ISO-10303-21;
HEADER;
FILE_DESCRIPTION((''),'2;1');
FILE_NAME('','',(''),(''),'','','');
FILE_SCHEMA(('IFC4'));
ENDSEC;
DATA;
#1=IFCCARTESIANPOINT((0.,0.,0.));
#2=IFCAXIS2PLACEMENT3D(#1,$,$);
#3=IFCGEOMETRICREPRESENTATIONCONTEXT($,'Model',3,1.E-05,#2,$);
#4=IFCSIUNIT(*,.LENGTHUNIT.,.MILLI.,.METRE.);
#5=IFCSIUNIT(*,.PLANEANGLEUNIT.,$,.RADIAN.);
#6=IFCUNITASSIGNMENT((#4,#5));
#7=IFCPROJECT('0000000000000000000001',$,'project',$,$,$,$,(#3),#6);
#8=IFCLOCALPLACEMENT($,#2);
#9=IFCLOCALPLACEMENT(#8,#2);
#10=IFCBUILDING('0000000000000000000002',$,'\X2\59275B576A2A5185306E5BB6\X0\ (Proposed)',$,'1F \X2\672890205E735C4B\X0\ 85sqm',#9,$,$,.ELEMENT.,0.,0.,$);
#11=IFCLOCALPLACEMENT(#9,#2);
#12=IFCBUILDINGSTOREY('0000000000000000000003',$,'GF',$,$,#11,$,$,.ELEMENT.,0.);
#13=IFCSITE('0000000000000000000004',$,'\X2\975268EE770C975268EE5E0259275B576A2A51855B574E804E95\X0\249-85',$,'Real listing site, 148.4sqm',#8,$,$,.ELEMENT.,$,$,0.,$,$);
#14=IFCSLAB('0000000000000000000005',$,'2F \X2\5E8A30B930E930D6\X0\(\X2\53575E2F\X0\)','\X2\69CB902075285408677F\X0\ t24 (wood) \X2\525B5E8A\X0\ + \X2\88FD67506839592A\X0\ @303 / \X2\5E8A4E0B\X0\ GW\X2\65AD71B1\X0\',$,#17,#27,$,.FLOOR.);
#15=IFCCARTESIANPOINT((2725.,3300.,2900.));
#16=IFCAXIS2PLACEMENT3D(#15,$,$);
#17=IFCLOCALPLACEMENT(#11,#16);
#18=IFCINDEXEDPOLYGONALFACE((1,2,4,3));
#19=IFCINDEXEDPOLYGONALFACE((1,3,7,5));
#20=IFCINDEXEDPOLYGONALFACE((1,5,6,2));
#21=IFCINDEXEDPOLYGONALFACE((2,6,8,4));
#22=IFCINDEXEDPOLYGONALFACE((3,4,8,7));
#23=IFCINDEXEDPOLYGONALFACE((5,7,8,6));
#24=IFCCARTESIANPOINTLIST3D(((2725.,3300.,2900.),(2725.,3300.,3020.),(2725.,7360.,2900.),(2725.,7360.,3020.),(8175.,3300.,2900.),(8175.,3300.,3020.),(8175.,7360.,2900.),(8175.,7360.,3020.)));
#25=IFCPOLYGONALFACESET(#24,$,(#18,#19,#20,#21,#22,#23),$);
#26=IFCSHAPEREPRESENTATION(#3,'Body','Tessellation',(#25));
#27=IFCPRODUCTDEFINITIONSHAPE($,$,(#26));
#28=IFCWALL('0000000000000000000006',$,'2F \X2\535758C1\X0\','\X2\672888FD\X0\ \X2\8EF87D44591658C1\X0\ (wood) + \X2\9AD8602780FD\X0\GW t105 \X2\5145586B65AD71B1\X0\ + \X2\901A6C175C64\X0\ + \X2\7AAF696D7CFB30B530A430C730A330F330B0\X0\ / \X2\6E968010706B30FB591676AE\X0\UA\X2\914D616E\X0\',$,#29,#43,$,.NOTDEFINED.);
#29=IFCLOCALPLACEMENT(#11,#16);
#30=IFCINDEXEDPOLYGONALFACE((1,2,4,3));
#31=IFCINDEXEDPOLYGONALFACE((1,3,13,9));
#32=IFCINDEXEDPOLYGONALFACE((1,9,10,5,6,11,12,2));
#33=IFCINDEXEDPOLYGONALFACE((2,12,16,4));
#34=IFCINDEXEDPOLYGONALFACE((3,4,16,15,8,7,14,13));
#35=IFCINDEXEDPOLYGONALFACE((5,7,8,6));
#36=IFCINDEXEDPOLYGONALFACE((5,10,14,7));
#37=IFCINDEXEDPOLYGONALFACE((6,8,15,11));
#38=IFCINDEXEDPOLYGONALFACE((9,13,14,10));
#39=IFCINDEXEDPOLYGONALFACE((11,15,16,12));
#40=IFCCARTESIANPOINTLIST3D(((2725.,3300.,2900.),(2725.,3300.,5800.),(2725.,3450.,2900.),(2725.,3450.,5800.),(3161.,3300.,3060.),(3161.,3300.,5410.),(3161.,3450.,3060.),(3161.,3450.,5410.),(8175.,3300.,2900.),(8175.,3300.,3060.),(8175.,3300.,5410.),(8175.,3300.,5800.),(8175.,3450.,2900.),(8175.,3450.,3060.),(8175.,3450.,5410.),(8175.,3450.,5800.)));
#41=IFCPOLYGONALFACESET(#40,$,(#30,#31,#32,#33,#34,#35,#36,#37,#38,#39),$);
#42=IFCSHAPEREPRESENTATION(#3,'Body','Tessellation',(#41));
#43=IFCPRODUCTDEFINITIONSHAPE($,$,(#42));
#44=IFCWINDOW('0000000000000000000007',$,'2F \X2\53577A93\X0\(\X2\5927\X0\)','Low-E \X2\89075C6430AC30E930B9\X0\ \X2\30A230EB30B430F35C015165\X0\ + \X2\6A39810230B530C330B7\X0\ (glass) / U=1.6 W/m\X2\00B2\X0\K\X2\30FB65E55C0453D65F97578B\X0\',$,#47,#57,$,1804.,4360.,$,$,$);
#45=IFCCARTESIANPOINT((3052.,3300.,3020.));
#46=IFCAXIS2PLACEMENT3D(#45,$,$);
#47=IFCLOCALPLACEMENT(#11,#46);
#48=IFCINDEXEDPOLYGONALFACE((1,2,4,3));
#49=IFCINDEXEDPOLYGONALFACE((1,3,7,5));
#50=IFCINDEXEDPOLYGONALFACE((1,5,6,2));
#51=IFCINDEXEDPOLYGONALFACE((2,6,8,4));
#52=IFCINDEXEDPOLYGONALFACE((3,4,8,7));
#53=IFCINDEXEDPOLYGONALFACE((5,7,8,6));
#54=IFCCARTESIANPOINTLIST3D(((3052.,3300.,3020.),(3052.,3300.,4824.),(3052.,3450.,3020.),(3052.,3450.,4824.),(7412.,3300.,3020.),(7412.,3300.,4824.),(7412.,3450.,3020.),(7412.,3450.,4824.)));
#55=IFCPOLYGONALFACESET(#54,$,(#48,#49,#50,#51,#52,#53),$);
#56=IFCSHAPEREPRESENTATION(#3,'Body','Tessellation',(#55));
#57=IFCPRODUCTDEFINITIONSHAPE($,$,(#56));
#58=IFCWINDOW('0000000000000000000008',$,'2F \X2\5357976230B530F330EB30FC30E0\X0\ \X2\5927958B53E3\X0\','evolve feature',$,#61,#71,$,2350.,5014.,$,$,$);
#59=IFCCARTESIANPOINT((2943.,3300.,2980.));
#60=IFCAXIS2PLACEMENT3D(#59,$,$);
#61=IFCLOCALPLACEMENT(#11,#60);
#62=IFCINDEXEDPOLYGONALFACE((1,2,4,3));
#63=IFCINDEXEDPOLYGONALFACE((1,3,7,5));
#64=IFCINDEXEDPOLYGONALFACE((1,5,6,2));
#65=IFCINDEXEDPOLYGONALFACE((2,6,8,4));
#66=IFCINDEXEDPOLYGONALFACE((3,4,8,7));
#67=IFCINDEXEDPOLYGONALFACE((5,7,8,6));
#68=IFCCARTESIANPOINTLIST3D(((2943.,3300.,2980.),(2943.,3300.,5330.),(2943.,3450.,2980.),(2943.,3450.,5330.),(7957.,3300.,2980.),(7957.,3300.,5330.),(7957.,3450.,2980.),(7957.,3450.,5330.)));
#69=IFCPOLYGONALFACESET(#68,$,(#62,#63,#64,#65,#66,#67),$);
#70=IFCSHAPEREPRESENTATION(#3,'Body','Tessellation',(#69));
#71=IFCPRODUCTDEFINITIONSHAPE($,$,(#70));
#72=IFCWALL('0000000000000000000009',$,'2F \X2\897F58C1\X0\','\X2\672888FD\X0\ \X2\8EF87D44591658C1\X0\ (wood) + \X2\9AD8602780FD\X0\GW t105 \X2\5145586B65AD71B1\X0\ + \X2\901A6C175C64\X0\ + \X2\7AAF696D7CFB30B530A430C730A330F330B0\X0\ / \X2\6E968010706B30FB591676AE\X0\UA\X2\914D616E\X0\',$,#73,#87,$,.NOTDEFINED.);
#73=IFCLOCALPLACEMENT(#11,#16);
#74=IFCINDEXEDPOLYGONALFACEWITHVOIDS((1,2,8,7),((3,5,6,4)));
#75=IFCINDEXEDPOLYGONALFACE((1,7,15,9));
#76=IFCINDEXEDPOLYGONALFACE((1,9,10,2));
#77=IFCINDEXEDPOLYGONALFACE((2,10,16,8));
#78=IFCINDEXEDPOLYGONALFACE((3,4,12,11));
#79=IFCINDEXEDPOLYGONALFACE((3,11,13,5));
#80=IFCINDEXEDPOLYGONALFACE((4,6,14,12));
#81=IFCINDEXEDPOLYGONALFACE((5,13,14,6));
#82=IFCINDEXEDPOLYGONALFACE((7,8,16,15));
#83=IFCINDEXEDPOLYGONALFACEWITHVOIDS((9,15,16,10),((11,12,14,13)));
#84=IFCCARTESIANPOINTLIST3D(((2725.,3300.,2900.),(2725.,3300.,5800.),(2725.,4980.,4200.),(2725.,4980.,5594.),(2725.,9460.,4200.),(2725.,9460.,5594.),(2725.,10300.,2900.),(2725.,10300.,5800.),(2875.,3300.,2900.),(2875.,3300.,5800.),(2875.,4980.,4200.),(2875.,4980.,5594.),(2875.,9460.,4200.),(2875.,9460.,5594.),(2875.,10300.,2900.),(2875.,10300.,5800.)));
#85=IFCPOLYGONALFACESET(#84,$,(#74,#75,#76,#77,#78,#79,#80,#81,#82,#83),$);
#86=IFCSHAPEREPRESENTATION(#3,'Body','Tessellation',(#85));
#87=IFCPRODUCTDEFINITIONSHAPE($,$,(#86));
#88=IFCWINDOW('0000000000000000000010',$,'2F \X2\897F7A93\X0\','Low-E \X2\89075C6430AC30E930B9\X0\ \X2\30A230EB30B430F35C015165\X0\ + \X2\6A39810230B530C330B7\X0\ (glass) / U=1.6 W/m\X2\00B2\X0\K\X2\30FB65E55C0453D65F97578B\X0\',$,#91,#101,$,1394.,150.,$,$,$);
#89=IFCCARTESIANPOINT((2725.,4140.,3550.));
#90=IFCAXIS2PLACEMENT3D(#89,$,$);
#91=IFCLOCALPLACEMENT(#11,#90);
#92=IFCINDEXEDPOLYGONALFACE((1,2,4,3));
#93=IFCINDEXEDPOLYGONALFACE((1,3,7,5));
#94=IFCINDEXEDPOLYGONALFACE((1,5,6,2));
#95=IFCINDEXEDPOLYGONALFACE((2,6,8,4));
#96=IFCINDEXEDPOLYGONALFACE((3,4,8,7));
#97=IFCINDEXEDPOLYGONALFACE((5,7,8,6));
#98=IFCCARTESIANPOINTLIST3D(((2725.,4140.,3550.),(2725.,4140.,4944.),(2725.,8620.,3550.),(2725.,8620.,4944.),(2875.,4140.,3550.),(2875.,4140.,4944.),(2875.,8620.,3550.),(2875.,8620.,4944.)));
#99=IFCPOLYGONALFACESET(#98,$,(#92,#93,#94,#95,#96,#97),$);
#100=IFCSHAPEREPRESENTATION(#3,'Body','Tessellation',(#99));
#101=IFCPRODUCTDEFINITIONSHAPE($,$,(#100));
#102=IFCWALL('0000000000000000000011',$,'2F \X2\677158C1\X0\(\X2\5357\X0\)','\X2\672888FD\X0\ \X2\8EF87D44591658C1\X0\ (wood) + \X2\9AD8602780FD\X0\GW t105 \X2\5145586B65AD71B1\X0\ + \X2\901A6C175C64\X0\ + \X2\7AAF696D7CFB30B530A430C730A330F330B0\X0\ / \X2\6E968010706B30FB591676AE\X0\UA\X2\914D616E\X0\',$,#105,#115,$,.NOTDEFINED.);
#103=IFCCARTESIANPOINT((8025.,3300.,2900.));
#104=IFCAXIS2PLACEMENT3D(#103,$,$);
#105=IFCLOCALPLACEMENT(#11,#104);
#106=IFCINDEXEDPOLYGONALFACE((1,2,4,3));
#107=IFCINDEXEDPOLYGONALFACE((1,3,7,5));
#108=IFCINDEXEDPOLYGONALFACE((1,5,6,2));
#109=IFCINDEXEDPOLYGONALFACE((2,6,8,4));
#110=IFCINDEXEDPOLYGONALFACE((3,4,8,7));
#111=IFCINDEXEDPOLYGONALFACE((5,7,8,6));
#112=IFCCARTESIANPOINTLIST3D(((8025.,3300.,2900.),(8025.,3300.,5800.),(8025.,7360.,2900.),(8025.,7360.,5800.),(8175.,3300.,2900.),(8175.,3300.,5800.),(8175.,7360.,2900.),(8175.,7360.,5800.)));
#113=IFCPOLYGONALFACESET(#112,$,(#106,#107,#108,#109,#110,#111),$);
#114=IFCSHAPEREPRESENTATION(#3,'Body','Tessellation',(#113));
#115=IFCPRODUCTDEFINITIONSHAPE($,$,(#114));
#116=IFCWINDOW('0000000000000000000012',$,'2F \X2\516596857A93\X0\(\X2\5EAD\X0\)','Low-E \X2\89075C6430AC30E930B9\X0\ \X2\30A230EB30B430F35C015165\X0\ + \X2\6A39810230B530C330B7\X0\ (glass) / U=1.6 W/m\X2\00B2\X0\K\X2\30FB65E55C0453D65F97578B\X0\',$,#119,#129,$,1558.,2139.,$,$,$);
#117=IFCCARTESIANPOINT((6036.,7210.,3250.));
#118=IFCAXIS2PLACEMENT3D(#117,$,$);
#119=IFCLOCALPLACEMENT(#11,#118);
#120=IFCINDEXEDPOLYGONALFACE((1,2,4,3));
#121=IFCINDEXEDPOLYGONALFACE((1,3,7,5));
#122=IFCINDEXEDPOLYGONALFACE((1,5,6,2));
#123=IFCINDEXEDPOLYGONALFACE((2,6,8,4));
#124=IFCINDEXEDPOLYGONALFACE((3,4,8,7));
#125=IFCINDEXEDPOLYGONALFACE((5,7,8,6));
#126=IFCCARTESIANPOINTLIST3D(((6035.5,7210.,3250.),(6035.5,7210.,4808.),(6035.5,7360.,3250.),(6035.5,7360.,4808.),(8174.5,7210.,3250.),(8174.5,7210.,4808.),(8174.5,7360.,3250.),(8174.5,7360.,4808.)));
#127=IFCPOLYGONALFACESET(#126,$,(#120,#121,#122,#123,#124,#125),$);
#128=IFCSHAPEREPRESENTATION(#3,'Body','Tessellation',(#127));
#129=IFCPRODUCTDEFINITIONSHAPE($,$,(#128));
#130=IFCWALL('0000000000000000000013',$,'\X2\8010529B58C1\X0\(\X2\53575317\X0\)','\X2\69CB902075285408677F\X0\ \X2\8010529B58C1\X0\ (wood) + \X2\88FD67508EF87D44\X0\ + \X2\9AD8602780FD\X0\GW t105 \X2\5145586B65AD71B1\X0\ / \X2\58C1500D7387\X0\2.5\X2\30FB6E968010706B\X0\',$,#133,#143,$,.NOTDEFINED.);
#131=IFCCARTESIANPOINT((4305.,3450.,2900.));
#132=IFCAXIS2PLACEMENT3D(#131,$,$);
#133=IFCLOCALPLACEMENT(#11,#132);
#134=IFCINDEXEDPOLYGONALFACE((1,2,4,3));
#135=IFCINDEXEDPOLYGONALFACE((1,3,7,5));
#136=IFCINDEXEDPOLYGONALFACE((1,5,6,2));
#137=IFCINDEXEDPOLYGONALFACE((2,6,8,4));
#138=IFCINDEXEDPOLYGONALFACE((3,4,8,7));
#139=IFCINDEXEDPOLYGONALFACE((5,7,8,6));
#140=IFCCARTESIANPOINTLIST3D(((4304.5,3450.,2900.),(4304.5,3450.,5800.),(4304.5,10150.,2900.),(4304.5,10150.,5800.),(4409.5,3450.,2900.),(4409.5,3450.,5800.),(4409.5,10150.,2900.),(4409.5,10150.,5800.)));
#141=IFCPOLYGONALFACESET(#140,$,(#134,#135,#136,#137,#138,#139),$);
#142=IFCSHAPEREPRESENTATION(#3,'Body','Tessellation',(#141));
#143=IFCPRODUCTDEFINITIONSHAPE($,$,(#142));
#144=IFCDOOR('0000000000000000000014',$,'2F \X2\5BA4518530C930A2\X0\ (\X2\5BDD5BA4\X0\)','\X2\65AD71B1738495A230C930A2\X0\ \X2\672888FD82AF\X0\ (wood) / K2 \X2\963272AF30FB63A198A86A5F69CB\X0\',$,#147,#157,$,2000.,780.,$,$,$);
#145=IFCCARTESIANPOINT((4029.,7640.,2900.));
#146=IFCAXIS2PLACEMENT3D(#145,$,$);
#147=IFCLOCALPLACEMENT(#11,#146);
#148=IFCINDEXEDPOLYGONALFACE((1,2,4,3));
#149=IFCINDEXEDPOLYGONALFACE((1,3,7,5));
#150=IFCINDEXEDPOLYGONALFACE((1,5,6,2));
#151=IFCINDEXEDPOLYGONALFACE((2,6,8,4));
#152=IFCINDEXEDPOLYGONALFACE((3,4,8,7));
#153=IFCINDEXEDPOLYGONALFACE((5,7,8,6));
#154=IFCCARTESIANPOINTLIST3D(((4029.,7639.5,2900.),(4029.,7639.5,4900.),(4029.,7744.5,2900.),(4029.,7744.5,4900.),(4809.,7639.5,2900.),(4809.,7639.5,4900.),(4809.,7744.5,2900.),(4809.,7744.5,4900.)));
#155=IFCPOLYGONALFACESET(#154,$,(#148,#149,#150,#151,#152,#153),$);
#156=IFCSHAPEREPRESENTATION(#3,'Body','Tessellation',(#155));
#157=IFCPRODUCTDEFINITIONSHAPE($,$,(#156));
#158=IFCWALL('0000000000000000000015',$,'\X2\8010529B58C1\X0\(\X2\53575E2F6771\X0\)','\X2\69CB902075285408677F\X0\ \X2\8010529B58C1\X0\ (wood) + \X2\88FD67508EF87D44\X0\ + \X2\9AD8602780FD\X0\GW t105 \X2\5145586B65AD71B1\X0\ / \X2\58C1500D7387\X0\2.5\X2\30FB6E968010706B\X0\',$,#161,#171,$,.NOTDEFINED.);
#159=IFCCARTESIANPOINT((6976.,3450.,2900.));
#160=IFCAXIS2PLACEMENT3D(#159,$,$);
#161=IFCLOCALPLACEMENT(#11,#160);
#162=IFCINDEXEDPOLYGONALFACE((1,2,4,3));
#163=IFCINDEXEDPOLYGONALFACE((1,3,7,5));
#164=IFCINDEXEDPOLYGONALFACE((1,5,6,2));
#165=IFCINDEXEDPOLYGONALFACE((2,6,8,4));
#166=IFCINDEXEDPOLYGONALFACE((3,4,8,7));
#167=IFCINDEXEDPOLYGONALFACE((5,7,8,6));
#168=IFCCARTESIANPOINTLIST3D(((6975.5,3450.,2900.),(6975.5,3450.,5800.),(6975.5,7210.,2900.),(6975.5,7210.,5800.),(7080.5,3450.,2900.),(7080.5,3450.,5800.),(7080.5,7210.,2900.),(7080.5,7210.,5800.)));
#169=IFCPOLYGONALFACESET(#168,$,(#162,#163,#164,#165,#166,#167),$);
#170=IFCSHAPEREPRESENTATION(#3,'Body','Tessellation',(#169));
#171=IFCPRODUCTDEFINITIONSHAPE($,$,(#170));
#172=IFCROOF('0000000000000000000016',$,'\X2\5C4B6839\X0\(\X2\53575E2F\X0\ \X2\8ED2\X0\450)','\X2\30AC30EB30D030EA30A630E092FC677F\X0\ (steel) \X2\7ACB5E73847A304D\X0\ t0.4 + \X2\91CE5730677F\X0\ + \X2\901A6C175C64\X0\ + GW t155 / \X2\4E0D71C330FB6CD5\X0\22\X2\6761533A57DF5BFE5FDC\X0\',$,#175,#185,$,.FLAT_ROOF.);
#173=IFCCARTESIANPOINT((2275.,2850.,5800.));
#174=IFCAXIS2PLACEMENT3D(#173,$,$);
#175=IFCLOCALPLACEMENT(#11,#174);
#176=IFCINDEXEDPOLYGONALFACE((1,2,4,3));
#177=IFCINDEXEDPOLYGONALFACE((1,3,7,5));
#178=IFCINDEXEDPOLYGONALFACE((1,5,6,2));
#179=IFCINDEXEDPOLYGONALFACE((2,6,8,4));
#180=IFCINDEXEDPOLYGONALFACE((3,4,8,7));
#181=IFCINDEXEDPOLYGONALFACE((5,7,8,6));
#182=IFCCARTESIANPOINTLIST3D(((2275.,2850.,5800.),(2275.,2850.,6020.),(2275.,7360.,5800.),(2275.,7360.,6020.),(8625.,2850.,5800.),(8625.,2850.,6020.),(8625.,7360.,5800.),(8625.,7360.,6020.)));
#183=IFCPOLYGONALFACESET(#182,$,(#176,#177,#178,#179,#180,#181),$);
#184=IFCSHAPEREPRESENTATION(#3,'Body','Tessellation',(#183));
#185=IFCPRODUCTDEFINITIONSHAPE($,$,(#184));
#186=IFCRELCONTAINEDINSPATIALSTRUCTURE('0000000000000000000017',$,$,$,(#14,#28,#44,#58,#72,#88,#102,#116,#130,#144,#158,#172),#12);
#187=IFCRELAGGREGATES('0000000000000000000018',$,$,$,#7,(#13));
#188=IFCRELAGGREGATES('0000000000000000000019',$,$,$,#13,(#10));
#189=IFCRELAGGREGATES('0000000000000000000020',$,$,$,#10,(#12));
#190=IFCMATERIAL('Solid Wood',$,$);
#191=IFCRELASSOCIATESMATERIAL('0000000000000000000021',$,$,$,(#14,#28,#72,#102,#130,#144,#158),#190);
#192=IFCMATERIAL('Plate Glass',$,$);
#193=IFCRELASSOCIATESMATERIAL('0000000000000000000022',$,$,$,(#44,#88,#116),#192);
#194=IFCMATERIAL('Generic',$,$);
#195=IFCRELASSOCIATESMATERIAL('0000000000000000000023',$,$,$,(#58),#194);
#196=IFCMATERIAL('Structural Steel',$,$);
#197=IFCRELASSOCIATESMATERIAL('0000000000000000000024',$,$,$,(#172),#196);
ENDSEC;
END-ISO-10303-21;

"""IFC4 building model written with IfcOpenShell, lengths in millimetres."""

from ifc_helpers import new_model, si_unit, frame, frame_2d, origin, place, context, project, spatial, rectangle, extrude, material, element, fill, save


model = new_model("IFC4")

# Units and contexts
model_context = context("Model", 3, precision=1e-05, world=origin())
ifc_project = project(units=[si_unit("LENGTHUNIT", "METRE", prefix="MILLI"), si_unit("PLANEANGLEUNIT", "RADIAN")], contexts=[model_context])

# Site, building, storey
site_placement = place(None, origin())
site = spatial("IfcSite", under=ifc_project, at=site_placement, Name="青森県青森市大字横内字亀井249-85", ObjectType="Real listing site, 148.4sqm", CompositionType="ELEMENT", RefElevation=0.0)
building_placement = place(site_placement, origin())
building = spatial("IfcBuilding", under=site, at=building_placement, Name="大字横内の家 (Proposed)", ObjectType="1F 木造平屋 85sqm", CompositionType="ELEMENT", ElevationOfRefHeight=0.0, ElevationOfTerrain=0.0)
storey_placement = place(building_placement, origin())
storey = spatial("IfcBuildingStorey", under=building, at=storey_placement, Name="GF", CompositionType="ELEMENT", Elevation=0.0)

# Slab
ifc_material_1 = material(Name="Solid Wood")
slab_placement = place(storey_placement, frame((2725.0, 3300.0, 2900.0)))
element("IfcSlab", 1, at=slab_placement, inside=storey, material=ifc_material_1, Name="2F 床スラブ(南帯)", Description="構造用合板 t24 (wood) 剛床 + 製材根太 @303 / 床下 GW断熱", PredefinedType="FLOOR", context=model_context, shape_type="SweptSolid", body=[
    extrude(rectangle(XDim=5450.0, YDim=4060.0, at=frame_2d((2725.0, 2030.0))), frame((2725.0, 3300.0, 2900.0)), (0.0, 0.0, 1.0), 120.0),
])

# Wall, openings, windows
wall_1_placement = place(storey_placement, frame((2725.0, 3300.0, 2900.0)))
wall_1 = element("IfcWall", 2, at=wall_1_placement, inside=storey, material=ifc_material_1, Name="2F 南壁", Description="木製 軸組外壁 (wood) + 高性能GW t105 充填断熱 + 通気層 + 窯業系サイディング / 準耐火・外皮UA配慮", PredefinedType="NOTDEFINED", context=model_context, shape_type="SweptSolid", body=[
    extrude(rectangle(XDim=5450.0, YDim=150.0, at=frame_2d((2725.0, 75.0))), frame((2725.0, 3300.0, 2900.0)), (0.0, 0.0, 1.0), 2900.0),
])
opening_1_placement = place(storey_placement, frame((3052.0, 3300.0, 3020.0)))
opening_1 = element("IfcOpeningElement", 3, at=opening_1_placement, cuts=wall_1, PredefinedType="NOTDEFINED", context=model_context, shape_type="SweptSolid", body=[
    extrude(rectangle(XDim=4360.0, YDim=150.0, at=frame_2d((2180.0, 75.0))), frame((3052.0, 3300.0, 3020.0)), (0.0, 0.0, 1.0), 1804.0),
])
opening_2_placement = place(storey_placement, frame((2943.0, 3300.0, 2980.0)))
opening_2 = element("IfcOpeningElement", 4, at=opening_2_placement, cuts=wall_1, PredefinedType="NOTDEFINED", context=model_context, shape_type="SweptSolid", body=[
    extrude(rectangle(XDim=5014.0, YDim=150.0, at=frame_2d((2507.0, 75.0))), frame((2943.0, 3300.0, 2980.0)), (0.0, 0.0, 1.0), 2350.0),
])
ifc_material_2 = material(Name="Plate Glass")
window_1_placement = place(storey_placement, frame((3052.0, 3300.0, 3020.0)))
window_1 = element("IfcWindow", 5, at=window_1_placement, inside=storey, material=ifc_material_2, Name="2F 南窓(大)", Description="Low-E 複層ガラス アルゴン封入 + 樹脂サッシ (glass) / U=1.6 W/m²K・日射取得型", OverallHeight=1804.0, OverallWidth=4360.0, context=model_context, shape_type="SweptSolid", body=[
    extrude(rectangle(XDim=4360.0, YDim=150.0, at=frame_2d((2180.0, 75.0))), frame((3052.0, 3300.0, 3020.0)), (0.0, 0.0, 1.0), 1804.0),
])
fill(opening_1, window_1)
ifc_material_3 = material(Name="Generic")
window_2_placement = place(storey_placement, frame((2943.0, 3300.0, 2980.0)))
window_2 = element("IfcWindow", 6, at=window_2_placement, inside=storey, material=ifc_material_3, Name="2F 南面サンルーム 大開口", Description="evolve feature", OverallHeight=2350.0, OverallWidth=5014.0, context=model_context, shape_type="SweptSolid", body=[
    extrude(rectangle(XDim=5014.0, YDim=150.0, at=frame_2d((2507.0, 75.0))), frame((2943.0, 3300.0, 2980.0)), (0.0, 0.0, 1.0), 2350.0),
])
fill(opening_2, window_2)

# Walls, openings, windows
wall_2_placement = place(storey_placement, frame((2725.0, 3300.0, 2900.0)))
wall_2 = element("IfcWall", 7, at=wall_2_placement, inside=storey, material=ifc_material_1, Name="2F 西壁", Description="木製 軸組外壁 (wood) + 高性能GW t105 充填断熱 + 通気層 + 窯業系サイディング / 準耐火・外皮UA配慮", PredefinedType="NOTDEFINED", context=model_context, shape_type="SweptSolid", body=[
    extrude(rectangle(XDim=150.0, YDim=7000.0, at=frame_2d((75.0, 3500.0))), frame((2725.0, 3300.0, 2900.0)), (0.0, 0.0, 1.0), 2900.0),
])
opening_3_placement = place(storey_placement, frame((2725.0, 4140.0, 3550.0)))
opening_3 = element("IfcOpeningElement", 8, at=opening_3_placement, cuts=wall_2, PredefinedType="NOTDEFINED", context=model_context, shape_type="SweptSolid", body=[
    extrude(rectangle(XDim=150.0, YDim=4480.0, at=frame_2d((75.0, 2240.0))), frame((2725.0, 4140.0, 3550.0)), (0.0, 0.0, 1.0), 1394.0),
])
window_3_placement = place(storey_placement, frame((2725.0, 4140.0, 3550.0)))
window_3 = element("IfcWindow", 9, at=window_3_placement, inside=storey, material=ifc_material_2, Name="2F 西窓", Description="Low-E 複層ガラス アルゴン封入 + 樹脂サッシ (glass) / U=1.6 W/m²K・日射取得型", OverallHeight=1394.0, OverallWidth=150.0, context=model_context, shape_type="SweptSolid", body=[
    extrude(rectangle(XDim=150.0, YDim=4480.0, at=frame_2d((75.0, 2240.0))), frame((2725.0, 4140.0, 3550.0)), (0.0, 0.0, 1.0), 1394.0),
])
fill(opening_3, window_3)
wall_3_placement = place(storey_placement, frame((8025.0, 3300.0, 2900.0)))
wall_3 = element("IfcWall", 10, at=wall_3_placement, inside=storey, material=ifc_material_1, Name="2F 東壁(南)", Description="木製 軸組外壁 (wood) + 高性能GW t105 充填断熱 + 通気層 + 窯業系サイディング / 準耐火・外皮UA配慮", PredefinedType="NOTDEFINED", context=model_context, shape_type="SweptSolid", body=[
    extrude(rectangle(XDim=150.0, YDim=4060.0, at=frame_2d((75.0, 2030.0))), frame((8025.0, 3300.0, 2900.0)), (0.0, 0.0, 1.0), 2900.0),
])
opening_4_placement = place(storey_placement, frame((6036.0, 7210.0, 3250.0)))
opening_4 = element("IfcOpeningElement", 11, at=opening_4_placement, cuts=wall_3, PredefinedType="NOTDEFINED", context=model_context, shape_type="SweptSolid", body=[
    extrude(rectangle(XDim=2139.0, YDim=150.0, at=frame_2d((1069.0, 75.0))), frame((6036.0, 7210.0, 3250.0)), (0.0, 0.0, 1.0), 1558.0),
])
window_4_placement = place(storey_placement, frame((6036.0, 7210.0, 3250.0)))
window_4 = element("IfcWindow", 12, at=window_4_placement, inside=storey, material=ifc_material_2, Name="2F 入隅窓(庭)", Description="Low-E 複層ガラス アルゴン封入 + 樹脂サッシ (glass) / U=1.6 W/m²K・日射取得型", OverallHeight=1558.0, OverallWidth=2139.0, context=model_context, shape_type="SweptSolid", body=[
    extrude(rectangle(XDim=2139.0, YDim=150.0, at=frame_2d((1069.0, 75.0))), frame((6036.0, 7210.0, 3250.0)), (0.0, 0.0, 1.0), 1558.0),
])
fill(opening_4, window_4)

# Wall, opening, door
wall_4_placement = place(storey_placement, frame((4305.0, 3450.0, 2900.0)))
wall_4 = element("IfcWall", 13, at=wall_4_placement, inside=storey, material=ifc_material_1, Name="耐力壁(南北)", Description="構造用合板 耐力壁 (wood) + 製材軸組 + 高性能GW t105 充填断熱 / 壁倍率2.5・準耐火", PredefinedType="NOTDEFINED", context=model_context, shape_type="SweptSolid", body=[
    extrude(rectangle(XDim=105.0, YDim=6700.0, at=frame_2d((52.0, 3350.0))), frame((4305.0, 3450.0, 2900.0)), (0.0, 0.0, 1.0), 2900.0),
])
opening_5_placement = place(storey_placement, frame((4029.0, 7640.0, 2900.0)))
opening_5 = element("IfcOpeningElement", 14, at=opening_5_placement, cuts=wall_4, PredefinedType="NOTDEFINED", context=model_context, shape_type="SweptSolid", body=[
    extrude(rectangle(XDim=780.0, YDim=105.0, at=frame_2d((390.0, 52.0))), frame((4029.0, 7640.0, 2900.0)), (0.0, 0.0, 1.0), 2000.0),
])
door_placement = place(storey_placement, frame((4029.0, 7640.0, 2900.0)))
door = element("IfcDoor", 15, at=door_placement, inside=storey, material=ifc_material_1, Name="2F 室内ドア (寝室)", Description="断熱玄関ドア 木製芯 (wood) / K2 防犯・採風機構", OverallHeight=2000.0, OverallWidth=780.0, context=model_context, shape_type="SweptSolid", body=[
    extrude(rectangle(XDim=780.0, YDim=105.0, at=frame_2d((390.0, 52.0))), frame((4029.0, 7640.0, 2900.0)), (0.0, 0.0, 1.0), 2000.0),
])
fill(opening_5, door)

# Wall
wall_5_placement = place(storey_placement, frame((6976.0, 3450.0, 2900.0)))
element("IfcWall", 16, at=wall_5_placement, inside=storey, material=ifc_material_1, Name="耐力壁(南帯東)", Description="構造用合板 耐力壁 (wood) + 製材軸組 + 高性能GW t105 充填断熱 / 壁倍率2.5・準耐火", PredefinedType="NOTDEFINED", context=model_context, shape_type="SweptSolid", body=[
    extrude(rectangle(XDim=105.0, YDim=3760.0, at=frame_2d((52.0, 1880.0))), frame((6976.0, 3450.0, 2900.0)), (0.0, 0.0, 1.0), 2900.0),
])

# Roof
ifc_material_4 = material(Name="Structural Steel")
for number, where, name in (
    (17, (2275.0, 2850.0, 5800.0), "屋根(南帯 軒450)"),
):
    element("IfcRoof", number, at=place(storey_placement, frame(where)), inside=storey, material=ifc_material_4, Name=name, Description="ガルバリウム鋼板 (steel) 立平葺き t0.4 + 野地板 + 通気層 + GW t155 / 不燃・法22条区域対応", PredefinedType="FLAT_ROOF", context=model_context, shape_type="SweptSolid", body=[
        extrude(rectangle(XDim=6350.0, YDim=4510.0, at=frame_2d((3175.0, 2255.0))), frame((2275.0, 2850.0, 5800.0)), (0.0, 0.0, 1.0), 220.0),
    ])

save(model, "model.ifc")
